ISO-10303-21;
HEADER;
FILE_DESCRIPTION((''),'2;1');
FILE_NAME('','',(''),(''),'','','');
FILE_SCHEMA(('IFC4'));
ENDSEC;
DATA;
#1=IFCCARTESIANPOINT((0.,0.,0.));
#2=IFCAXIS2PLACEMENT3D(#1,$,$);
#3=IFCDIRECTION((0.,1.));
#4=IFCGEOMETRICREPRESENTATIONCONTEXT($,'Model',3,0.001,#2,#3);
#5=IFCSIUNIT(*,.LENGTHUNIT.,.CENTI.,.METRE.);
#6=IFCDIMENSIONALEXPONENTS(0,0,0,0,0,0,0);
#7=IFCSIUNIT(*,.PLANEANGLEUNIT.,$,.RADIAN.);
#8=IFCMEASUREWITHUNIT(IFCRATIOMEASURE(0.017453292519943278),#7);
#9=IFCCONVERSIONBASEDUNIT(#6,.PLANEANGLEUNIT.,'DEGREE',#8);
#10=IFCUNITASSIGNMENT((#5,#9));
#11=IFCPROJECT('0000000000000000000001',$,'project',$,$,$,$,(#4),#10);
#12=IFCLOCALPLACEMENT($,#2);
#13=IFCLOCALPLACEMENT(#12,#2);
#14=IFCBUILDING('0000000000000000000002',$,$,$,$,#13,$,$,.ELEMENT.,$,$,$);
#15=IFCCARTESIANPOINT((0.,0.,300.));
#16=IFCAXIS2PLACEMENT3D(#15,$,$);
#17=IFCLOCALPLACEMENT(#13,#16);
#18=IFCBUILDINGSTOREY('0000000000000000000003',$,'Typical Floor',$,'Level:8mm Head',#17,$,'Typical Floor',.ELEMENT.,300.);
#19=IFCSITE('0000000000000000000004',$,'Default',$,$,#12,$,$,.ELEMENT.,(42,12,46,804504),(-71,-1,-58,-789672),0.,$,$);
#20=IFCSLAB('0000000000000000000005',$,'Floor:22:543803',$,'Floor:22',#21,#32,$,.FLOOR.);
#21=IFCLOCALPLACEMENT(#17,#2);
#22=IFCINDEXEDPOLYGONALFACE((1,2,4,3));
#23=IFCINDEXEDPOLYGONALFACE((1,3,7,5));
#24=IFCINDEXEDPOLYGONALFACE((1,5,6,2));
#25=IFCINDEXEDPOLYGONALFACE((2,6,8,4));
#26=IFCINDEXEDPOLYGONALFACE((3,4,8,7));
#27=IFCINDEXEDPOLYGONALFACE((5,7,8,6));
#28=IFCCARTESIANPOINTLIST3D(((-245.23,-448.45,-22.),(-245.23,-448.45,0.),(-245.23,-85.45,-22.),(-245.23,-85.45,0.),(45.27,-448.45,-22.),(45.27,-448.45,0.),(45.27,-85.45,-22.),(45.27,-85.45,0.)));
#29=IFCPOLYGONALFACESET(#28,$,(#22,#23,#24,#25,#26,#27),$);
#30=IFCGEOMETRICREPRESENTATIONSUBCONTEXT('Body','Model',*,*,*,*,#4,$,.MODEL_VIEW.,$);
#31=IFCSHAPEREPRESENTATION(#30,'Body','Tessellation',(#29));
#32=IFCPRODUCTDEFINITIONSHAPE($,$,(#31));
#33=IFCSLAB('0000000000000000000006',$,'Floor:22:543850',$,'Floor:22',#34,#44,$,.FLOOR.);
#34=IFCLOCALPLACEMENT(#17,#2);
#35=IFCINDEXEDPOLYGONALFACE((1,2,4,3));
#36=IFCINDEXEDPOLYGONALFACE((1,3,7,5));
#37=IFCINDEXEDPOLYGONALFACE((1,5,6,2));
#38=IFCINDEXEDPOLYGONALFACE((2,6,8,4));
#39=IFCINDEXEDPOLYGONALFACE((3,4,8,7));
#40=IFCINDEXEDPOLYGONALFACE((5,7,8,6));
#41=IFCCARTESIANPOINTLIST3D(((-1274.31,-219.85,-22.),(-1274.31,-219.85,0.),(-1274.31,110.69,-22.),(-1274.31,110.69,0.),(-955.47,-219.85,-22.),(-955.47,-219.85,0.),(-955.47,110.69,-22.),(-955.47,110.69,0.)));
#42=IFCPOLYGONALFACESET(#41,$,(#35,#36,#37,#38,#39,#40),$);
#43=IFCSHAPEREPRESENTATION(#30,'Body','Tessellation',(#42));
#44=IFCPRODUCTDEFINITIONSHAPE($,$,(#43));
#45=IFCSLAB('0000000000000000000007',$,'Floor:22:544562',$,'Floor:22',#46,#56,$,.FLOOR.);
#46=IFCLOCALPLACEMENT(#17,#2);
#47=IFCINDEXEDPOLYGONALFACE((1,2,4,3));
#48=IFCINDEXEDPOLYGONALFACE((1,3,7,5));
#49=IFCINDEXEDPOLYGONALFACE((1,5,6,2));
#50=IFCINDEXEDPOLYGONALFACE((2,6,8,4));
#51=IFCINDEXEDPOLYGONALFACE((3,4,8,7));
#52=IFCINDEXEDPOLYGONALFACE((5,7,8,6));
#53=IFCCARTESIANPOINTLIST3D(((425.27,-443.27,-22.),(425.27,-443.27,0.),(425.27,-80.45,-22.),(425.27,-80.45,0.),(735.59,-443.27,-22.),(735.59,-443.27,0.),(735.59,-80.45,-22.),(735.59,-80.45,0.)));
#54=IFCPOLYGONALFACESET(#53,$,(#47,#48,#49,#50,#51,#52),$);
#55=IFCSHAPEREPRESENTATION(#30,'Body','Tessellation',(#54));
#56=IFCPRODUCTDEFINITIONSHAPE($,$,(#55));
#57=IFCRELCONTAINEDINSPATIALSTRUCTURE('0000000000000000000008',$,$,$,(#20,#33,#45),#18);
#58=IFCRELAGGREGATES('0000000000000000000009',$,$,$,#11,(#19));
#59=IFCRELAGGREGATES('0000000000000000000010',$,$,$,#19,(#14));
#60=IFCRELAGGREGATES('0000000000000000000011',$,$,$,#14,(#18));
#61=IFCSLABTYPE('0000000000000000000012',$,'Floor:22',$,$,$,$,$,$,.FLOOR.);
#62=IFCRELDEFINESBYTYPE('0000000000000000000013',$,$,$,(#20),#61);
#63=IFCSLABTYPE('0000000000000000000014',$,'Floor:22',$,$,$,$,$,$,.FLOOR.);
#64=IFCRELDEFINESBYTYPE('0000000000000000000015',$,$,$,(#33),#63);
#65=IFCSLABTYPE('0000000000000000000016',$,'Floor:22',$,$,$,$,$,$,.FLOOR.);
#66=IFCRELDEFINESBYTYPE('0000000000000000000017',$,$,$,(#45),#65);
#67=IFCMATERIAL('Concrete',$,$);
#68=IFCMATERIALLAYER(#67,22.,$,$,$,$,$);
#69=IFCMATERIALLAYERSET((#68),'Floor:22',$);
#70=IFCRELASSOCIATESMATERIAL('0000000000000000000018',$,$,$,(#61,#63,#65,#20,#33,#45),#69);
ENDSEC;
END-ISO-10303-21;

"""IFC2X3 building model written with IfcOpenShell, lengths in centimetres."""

from ifc_helpers import new_model, entity, si_unit, converted_unit, direction, frame, frame_2d, origin, place, context, subcontext, project, spatial, rectangle, extrude, material, layer, layer_set, layer_usage, type_object, element, save


model = new_model("IFC2X3")

# Units and contexts
model_context = context("Model", 3, precision=0.001, world=origin(), true_north=direction((0.0, 1.0)))
body_context = subcontext(model_context, "Body", "Model", "MODEL_VIEW")
ifc_project = project(units=[si_unit("LENGTHUNIT", "METRE", prefix="CENTI"), converted_unit("PLANEANGLEUNIT", "DEGREE", entity("IfcRatioMeasure", 0.017453292519943278), si_unit("PLANEANGLEUNIT", "RADIAN"), dimensions=[0, 0, 0, 0, 0, 0, 0])], contexts=[model_context])

# Site, building, storey
site_placement = place(None, origin())
site = spatial("IfcSite", under=ifc_project, at=site_placement, Name="Default", CompositionType="ELEMENT", RefLatitude=(42, 12, 46, 804504), RefLongitude=(-71, -1, -58, -789672), RefElevation=0.0)
building_placement = place(site_placement, origin())
building = spatial("IfcBuilding", under=site, at=building_placement, CompositionType="ELEMENT")
storey_placement = place(building_placement, frame((0.0, 0.0, 300.0)))
storey = spatial("IfcBuildingStorey", under=building, at=storey_placement, Name="Typical Floor", ObjectType="Level:8mm Head", LongName="Typical Floor", CompositionType="ELEMENT", Elevation=300.0)

# Shared definitions
ifc_material = material(Name="Concrete")

# Slabs
ifc_layer = layer(ifc_material, 22.0)
ifc_layer_set = layer_set([ifc_layer], Name="Floor:22")
ifc_layer_usage_1 = layer_usage(ifc_layer_set, "AXIS3", "POSITIVE", 0.0)
slab_type_1 = type_object("IfcSlabType", Name="Floor:22", PredefinedType="FLOOR", material=ifc_layer_set)
slab_1_placement = place(storey_placement, origin())
element("IfcSlab", 1, at=slab_1_placement, inside=storey, type_object=slab_type_1, material=ifc_layer_usage_1, Name="Floor:22:543803", ObjectType="Floor:22", PredefinedType="FLOOR", context=body_context, shape_type="SweptSolid", body=[
    extrude(rectangle(XDim=363.0, YDim=290.5, at=frame_2d((0.0, 0.0), x_axis=(1.0, 0.0))), frame((-99.98, -266.95, 0.0), z_axis=(0.0, 0.0, -1.0), x_axis=(0.0, 1.0, 0.0)), (0.0, 0.0, 1.0), 22.0),
])
ifc_layer_usage_2 = layer_usage(ifc_layer_set, "AXIS3", "POSITIVE", 0.0)
slab_type_2 = type_object("IfcSlabType", Name="Floor:22", PredefinedType="FLOOR", material=ifc_layer_set)
slab_2_placement = place(storey_placement, origin())
element("IfcSlab", 2, at=slab_2_placement, inside=storey, type_object=slab_type_2, material=ifc_layer_usage_2, Name="Floor:22:543850", ObjectType="Floor:22", PredefinedType="FLOOR", context=body_context, shape_type="SweptSolid", body=[
    extrude(rectangle(XDim=330.54, YDim=318.84, at=frame_2d((0.0, 0.0), x_axis=(1.0, 0.0))), frame((-1114.89, -54.58, 0.0), z_axis=(0.0, 0.0, -1.0), x_axis=(0.0, 1.0, 0.0)), (0.0, 0.0, 1.0), 22.0),
])
ifc_layer_usage_3 = layer_usage(ifc_layer_set, "AXIS3", "POSITIVE", 0.0)
slab_type_3 = type_object("IfcSlabType", Name="Floor:22", PredefinedType="FLOOR", material=ifc_layer_set)
slab_3_placement = place(storey_placement, origin())
element("IfcSlab", 3, at=slab_3_placement, inside=storey, type_object=slab_type_3, material=ifc_layer_usage_3, Name="Floor:22:544562", ObjectType="Floor:22", PredefinedType="FLOOR", context=body_context, shape_type="SweptSolid", body=[
    extrude(rectangle(XDim=362.82, YDim=310.32, at=frame_2d((0.0, 0.0), x_axis=(1.0, 0.0))), frame((580.43, -261.86, 0.0), z_axis=(0.0, 0.0, -1.0), x_axis=(0.0, 1.0, 0.0)), (0.0, 0.0, 1.0), 22.0),
])

save(model, "model.ifc")
